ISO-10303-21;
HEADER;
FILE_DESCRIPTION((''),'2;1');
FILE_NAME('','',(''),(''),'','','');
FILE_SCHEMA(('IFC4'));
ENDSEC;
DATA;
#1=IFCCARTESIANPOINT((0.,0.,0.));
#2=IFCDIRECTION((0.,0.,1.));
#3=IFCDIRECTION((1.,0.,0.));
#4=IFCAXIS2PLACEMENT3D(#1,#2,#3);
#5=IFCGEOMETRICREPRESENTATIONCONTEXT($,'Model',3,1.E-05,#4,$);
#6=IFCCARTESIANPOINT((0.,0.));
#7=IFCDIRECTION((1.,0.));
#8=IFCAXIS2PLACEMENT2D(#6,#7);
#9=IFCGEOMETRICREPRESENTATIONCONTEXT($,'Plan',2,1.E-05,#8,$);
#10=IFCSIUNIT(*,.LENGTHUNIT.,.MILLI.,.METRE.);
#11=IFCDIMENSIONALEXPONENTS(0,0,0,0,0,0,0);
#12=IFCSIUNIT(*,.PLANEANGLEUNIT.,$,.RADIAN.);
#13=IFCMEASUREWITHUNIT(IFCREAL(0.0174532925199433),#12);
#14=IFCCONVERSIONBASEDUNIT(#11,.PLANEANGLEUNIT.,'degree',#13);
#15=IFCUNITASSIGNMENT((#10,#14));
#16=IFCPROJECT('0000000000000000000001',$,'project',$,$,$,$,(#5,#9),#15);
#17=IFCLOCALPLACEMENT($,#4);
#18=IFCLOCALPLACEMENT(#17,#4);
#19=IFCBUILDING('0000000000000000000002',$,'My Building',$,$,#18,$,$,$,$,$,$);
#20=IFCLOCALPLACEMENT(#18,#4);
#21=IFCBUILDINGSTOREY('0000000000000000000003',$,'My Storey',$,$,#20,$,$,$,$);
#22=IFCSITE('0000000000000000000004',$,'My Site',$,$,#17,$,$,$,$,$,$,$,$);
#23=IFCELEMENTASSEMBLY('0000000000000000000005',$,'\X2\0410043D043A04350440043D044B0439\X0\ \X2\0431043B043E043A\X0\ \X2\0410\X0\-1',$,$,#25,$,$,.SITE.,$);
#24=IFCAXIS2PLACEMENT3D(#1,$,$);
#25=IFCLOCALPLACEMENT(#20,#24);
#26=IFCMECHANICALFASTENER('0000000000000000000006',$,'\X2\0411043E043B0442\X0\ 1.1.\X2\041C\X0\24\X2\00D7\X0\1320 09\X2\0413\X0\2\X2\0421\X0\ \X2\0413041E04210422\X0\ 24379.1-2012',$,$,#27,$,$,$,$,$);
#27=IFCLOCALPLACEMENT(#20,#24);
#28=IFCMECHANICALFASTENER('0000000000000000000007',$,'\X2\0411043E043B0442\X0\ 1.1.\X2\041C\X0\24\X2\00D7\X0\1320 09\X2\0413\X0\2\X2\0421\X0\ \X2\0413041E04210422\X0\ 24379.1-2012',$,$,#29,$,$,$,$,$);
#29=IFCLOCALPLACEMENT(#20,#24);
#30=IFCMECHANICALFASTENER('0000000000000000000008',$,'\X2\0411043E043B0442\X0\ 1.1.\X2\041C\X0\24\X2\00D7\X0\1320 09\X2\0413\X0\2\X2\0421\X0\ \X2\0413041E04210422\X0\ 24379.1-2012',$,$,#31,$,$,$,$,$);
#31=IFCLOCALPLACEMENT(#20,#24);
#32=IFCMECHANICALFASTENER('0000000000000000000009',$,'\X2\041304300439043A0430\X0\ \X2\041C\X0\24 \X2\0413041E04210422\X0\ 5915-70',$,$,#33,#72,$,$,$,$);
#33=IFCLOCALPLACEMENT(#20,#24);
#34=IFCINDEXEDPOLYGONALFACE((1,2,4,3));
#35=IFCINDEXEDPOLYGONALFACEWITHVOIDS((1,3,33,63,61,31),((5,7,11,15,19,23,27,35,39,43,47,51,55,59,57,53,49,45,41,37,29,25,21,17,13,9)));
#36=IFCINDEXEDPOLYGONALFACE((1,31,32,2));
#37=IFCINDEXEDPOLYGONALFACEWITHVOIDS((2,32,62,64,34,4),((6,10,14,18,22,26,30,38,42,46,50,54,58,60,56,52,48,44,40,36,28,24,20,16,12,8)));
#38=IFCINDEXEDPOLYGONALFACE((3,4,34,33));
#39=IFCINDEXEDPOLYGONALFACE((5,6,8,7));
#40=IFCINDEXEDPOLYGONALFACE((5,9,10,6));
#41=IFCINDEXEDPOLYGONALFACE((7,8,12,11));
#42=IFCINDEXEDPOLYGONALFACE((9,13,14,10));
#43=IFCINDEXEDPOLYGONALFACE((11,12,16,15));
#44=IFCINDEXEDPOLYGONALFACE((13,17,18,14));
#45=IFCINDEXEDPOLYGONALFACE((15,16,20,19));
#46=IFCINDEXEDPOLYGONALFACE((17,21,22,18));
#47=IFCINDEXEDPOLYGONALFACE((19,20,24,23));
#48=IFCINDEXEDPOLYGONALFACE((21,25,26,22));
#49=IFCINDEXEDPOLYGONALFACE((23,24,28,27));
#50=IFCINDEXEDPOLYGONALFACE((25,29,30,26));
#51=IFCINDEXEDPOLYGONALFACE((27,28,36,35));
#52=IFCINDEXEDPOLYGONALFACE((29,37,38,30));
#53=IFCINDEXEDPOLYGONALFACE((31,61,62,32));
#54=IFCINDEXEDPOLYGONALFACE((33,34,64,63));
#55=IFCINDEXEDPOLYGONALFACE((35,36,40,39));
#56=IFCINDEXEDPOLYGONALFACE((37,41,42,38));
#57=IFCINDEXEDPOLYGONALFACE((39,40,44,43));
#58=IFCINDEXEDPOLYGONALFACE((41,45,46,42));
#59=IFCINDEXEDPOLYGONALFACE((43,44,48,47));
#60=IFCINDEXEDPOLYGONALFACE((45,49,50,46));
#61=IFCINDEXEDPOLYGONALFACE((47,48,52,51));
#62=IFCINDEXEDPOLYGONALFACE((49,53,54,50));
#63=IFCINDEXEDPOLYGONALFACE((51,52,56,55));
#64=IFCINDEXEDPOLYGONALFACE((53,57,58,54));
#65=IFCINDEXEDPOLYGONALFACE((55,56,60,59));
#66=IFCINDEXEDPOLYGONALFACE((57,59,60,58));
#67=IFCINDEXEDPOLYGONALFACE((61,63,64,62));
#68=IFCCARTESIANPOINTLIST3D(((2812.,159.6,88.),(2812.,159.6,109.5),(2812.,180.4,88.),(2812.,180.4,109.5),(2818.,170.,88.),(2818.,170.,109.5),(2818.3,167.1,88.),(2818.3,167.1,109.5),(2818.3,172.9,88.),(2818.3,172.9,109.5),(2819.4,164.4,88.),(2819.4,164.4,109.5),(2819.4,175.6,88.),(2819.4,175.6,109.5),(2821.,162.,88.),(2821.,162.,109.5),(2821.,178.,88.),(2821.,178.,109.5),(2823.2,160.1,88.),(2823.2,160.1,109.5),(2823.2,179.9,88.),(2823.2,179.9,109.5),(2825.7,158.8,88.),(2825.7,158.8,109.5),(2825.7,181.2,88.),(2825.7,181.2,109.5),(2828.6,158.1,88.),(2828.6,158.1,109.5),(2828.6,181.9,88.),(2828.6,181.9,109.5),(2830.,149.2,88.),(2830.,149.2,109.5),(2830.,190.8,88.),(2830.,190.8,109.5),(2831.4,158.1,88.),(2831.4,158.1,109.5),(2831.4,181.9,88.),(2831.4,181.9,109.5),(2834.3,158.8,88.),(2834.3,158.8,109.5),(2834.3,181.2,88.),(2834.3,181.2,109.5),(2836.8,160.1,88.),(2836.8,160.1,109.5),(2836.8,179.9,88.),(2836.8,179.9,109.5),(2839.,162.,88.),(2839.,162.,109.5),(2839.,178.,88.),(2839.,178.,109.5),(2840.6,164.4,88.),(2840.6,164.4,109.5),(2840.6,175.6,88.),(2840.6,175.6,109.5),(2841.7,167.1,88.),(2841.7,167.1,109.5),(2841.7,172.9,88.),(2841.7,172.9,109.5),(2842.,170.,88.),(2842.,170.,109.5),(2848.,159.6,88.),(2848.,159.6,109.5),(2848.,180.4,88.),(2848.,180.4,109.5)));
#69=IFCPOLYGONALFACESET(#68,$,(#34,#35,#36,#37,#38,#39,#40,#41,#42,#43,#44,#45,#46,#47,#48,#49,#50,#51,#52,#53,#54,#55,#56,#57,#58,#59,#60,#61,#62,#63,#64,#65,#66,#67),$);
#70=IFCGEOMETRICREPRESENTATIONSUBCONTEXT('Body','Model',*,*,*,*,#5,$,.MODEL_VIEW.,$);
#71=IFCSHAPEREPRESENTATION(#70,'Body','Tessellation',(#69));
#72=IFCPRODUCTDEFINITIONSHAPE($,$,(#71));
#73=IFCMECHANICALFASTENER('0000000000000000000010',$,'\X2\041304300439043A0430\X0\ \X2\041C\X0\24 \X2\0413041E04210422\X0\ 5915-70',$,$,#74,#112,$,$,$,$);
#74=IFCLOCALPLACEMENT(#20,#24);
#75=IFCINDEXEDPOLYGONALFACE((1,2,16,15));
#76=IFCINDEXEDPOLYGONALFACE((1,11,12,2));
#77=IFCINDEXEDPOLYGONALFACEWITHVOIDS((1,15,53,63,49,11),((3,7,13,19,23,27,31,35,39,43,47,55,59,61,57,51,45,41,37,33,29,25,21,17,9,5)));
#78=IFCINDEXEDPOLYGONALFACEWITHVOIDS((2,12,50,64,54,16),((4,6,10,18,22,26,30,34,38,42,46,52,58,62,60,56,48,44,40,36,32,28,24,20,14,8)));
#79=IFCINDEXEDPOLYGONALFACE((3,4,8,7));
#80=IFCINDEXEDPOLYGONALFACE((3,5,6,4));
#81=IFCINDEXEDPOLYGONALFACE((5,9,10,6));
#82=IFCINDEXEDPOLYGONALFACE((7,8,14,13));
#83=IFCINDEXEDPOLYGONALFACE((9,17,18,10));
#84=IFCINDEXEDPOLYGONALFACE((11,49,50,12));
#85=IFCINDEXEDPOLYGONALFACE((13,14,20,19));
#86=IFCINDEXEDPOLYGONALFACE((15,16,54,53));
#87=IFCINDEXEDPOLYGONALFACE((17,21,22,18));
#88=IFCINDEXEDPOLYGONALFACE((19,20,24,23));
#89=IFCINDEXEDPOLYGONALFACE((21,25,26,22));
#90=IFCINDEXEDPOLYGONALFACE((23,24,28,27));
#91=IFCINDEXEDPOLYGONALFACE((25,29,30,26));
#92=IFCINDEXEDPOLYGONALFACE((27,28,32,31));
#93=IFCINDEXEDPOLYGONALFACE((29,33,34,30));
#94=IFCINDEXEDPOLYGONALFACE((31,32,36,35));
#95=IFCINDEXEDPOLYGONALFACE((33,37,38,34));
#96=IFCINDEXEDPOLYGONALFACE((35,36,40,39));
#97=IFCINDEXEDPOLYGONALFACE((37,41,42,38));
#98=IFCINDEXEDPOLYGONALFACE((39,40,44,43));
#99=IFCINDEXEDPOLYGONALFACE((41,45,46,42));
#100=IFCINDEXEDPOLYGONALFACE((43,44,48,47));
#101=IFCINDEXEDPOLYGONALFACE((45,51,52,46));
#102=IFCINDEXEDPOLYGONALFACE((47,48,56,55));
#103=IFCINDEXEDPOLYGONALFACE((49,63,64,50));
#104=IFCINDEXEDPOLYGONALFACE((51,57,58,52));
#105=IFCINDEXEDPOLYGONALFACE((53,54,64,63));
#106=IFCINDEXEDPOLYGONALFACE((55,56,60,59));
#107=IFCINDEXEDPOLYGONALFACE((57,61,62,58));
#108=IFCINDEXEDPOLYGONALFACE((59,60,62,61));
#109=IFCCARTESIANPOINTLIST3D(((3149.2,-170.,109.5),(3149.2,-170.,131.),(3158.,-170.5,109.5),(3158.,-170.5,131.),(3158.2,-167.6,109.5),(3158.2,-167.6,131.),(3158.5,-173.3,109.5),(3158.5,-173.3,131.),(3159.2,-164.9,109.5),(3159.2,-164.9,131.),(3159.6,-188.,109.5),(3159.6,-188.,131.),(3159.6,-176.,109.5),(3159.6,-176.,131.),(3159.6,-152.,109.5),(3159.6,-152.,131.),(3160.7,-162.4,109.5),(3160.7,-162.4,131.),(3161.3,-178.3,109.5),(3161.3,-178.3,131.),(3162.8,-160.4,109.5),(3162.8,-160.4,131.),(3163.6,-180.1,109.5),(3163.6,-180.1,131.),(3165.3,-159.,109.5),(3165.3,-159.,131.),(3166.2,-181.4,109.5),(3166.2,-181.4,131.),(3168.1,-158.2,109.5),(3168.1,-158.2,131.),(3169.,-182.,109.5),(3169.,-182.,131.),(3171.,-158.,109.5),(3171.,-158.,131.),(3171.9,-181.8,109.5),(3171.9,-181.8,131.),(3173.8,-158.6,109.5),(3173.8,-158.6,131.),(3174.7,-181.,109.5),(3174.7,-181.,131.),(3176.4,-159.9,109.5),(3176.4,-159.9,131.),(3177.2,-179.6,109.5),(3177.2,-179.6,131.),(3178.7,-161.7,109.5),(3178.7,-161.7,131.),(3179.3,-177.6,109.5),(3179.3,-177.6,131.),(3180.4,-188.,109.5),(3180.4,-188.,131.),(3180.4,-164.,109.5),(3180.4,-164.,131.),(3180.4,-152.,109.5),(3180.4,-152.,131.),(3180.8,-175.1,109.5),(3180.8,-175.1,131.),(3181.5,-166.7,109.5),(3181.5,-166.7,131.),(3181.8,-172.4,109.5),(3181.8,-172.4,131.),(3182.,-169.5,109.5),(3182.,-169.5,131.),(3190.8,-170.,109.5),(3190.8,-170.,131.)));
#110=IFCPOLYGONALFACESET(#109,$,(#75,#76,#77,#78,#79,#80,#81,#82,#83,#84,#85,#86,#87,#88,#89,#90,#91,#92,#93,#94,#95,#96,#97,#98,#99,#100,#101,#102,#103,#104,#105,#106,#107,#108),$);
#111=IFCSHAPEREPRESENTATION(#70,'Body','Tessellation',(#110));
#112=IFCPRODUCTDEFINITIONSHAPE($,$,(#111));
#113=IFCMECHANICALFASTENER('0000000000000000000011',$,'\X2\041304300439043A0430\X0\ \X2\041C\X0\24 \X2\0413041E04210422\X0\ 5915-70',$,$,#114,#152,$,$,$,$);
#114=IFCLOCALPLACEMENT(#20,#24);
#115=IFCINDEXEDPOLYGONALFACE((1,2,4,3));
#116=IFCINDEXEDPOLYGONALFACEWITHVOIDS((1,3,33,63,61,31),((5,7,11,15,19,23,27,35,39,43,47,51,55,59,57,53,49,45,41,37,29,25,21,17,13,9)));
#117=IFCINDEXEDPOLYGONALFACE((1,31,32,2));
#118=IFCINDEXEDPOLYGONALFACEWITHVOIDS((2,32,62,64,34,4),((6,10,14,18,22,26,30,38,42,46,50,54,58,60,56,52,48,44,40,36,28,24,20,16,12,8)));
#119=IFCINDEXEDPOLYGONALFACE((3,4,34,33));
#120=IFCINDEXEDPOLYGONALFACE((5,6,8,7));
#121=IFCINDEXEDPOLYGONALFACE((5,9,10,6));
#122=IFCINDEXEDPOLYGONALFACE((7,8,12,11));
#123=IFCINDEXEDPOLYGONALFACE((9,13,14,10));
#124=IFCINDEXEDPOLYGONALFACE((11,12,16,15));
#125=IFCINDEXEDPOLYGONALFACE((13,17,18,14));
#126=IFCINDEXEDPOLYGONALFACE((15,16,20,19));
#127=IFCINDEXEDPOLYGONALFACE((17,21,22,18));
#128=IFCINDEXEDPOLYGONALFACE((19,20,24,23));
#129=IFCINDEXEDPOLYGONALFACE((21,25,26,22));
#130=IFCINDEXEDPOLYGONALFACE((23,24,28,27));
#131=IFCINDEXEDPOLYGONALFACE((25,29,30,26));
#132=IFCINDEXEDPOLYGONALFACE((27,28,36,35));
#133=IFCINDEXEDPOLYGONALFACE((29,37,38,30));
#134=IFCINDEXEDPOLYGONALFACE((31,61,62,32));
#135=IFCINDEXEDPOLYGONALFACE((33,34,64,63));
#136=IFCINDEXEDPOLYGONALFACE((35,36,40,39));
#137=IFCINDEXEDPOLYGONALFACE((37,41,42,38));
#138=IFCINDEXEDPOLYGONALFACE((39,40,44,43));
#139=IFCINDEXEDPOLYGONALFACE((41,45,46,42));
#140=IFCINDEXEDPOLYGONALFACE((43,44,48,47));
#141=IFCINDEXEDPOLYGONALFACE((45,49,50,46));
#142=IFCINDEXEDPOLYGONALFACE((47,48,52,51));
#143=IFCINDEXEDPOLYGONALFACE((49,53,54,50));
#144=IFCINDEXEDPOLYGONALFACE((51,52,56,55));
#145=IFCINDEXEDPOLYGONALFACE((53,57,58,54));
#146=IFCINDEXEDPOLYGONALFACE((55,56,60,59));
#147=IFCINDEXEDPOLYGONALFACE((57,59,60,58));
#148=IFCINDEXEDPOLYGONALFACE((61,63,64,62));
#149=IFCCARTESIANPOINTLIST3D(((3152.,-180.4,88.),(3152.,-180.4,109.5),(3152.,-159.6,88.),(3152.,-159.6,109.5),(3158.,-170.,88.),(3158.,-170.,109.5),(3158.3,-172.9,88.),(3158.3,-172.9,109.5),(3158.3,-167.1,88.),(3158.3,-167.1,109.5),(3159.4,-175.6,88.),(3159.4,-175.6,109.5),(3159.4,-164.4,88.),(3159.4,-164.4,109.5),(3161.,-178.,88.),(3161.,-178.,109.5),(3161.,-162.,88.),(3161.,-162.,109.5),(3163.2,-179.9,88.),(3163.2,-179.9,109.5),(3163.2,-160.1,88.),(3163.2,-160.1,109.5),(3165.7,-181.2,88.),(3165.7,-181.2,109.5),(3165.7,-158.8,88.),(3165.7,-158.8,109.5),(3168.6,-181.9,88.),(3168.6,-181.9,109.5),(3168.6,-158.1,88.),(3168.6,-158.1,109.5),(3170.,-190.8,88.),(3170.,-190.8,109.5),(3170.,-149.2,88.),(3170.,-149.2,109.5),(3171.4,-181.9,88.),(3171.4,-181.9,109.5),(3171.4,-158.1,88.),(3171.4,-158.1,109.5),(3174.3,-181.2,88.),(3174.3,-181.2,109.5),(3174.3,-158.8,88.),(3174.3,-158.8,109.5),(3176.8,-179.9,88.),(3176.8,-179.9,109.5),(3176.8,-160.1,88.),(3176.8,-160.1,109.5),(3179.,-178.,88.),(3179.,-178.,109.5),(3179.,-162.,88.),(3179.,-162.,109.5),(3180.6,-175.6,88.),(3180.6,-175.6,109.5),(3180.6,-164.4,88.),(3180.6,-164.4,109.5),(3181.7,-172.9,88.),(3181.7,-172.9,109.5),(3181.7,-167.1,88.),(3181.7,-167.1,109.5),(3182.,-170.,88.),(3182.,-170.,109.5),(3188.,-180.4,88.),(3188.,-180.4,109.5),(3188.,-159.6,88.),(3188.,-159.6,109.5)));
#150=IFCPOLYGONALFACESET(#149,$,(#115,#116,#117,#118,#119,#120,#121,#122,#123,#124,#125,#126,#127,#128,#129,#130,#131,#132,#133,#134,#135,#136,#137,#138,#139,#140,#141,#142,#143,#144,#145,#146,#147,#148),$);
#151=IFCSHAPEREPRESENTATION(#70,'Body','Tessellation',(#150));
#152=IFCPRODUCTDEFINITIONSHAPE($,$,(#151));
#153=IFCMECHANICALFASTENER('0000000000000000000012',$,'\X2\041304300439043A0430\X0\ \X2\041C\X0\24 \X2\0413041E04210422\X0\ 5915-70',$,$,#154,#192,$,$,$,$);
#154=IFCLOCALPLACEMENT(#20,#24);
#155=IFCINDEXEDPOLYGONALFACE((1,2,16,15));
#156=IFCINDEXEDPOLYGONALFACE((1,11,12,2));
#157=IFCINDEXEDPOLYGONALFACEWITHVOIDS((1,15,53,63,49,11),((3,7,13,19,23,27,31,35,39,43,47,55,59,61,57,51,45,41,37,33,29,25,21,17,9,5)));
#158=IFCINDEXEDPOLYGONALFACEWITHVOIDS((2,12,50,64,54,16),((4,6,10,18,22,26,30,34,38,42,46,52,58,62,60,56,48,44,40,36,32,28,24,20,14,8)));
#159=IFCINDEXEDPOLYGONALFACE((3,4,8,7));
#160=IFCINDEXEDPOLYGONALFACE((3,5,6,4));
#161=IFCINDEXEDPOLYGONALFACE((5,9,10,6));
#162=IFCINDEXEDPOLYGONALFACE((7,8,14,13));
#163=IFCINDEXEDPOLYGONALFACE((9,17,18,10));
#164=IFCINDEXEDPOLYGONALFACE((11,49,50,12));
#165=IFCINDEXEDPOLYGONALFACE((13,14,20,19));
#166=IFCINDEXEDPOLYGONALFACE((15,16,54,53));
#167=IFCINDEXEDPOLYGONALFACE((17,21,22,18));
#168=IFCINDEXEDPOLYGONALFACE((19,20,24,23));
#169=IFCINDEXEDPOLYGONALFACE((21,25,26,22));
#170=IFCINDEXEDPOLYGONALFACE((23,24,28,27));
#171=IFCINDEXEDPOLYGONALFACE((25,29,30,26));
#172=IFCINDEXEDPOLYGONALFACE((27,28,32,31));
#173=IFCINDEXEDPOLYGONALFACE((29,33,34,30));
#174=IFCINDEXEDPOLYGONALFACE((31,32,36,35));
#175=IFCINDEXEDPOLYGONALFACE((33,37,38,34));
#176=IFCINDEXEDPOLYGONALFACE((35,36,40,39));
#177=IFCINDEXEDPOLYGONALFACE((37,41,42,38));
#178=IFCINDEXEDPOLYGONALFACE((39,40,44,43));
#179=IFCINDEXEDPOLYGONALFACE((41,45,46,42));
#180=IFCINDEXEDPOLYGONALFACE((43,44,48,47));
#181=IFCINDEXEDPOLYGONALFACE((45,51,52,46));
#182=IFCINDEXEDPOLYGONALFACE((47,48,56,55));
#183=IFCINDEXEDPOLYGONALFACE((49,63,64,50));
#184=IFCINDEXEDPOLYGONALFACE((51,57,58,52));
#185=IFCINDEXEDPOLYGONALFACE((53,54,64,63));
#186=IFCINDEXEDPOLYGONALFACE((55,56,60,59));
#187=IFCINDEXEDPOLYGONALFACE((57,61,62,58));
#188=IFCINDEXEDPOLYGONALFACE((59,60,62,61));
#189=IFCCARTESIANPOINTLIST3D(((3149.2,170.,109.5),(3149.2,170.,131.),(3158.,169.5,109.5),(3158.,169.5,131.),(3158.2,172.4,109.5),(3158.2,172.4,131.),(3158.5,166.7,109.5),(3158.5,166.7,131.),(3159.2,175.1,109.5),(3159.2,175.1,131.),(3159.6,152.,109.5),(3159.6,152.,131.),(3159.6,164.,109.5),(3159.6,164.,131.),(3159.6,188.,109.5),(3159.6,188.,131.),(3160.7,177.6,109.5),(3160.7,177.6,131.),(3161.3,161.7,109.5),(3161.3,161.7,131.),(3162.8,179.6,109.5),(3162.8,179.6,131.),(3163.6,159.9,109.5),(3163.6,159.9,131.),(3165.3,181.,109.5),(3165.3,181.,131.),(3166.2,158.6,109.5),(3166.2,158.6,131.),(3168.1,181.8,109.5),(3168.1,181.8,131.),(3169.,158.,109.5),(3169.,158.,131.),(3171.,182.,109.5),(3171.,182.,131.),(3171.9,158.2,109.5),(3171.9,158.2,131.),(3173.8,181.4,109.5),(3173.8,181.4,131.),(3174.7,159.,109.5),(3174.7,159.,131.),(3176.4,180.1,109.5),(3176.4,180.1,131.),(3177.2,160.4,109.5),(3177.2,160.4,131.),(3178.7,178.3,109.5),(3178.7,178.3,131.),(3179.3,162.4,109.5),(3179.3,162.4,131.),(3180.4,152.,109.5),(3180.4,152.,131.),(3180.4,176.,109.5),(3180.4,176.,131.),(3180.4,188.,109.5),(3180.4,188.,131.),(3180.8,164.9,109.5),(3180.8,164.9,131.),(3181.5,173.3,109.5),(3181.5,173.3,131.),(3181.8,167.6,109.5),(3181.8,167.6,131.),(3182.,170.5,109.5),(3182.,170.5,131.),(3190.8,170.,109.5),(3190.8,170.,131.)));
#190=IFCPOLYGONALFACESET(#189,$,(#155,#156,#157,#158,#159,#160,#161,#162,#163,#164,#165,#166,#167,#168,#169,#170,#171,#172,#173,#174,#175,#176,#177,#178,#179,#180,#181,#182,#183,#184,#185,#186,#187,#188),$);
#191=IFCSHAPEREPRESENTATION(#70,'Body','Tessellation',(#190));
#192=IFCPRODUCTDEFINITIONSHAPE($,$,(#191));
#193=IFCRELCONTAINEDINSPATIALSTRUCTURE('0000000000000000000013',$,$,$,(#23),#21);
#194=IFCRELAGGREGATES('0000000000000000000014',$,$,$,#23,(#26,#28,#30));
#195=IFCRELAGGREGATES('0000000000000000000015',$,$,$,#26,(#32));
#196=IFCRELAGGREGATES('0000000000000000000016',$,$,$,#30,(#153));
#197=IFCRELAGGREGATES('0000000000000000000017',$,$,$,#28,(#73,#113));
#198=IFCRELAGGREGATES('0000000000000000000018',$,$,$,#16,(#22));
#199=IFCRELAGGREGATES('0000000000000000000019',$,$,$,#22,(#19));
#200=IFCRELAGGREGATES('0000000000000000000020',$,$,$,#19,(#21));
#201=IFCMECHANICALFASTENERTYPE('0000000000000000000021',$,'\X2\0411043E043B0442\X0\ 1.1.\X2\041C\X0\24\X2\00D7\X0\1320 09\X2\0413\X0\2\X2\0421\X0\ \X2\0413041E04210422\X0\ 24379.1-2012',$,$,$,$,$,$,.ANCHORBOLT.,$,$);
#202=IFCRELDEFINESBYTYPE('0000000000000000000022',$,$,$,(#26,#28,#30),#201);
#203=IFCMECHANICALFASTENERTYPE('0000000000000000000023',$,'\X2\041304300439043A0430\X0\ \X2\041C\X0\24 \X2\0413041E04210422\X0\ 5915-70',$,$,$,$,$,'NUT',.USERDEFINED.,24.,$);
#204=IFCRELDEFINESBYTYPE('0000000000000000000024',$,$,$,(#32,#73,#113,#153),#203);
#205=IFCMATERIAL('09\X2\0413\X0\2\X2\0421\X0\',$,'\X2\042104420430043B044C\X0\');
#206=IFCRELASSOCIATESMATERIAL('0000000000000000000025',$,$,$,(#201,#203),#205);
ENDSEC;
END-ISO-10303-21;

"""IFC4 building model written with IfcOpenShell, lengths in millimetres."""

from ifc_helpers import new_model, entity, si_unit, converted_unit, frame, origin_with_axes, origin_2d_with_axis, place, context, subcontext, project, spatial, polyline, outline, extrude, source, transform, mapped, material, type_object, type_shapes, element, aggregate, save


model = new_model("IFC4")

# Units and contexts
model_context = context("Model", 3, precision=1e-05, world=origin_with_axes())
plan_context = context("Plan", 2, precision=1e-05, world=origin_2d_with_axis())
body_context = subcontext(model_context, "Body", "Model", "MODEL_VIEW")
ifc_project = project(units=[si_unit("LENGTHUNIT", "METRE", prefix="MILLI"), converted_unit("PLANEANGLEUNIT", "degree", entity("IfcReal", 0.0174532925199433), si_unit("PLANEANGLEUNIT", "RADIAN"), dimensions=[0, 0, 0, 0, 0, 0, 0])], contexts=[model_context, plan_context])

# Site, building, storey
site_placement = place(None, origin_with_axes())
site = spatial("IfcSite", under=ifc_project, at=site_placement, Name="My Site")
building_placement = place(site_placement, origin_with_axes())
building = spatial("IfcBuilding", under=site, at=building_placement, Name="My Building")
storey_placement = place(building_placement, origin_with_axes())
storey = spatial("IfcBuildingStorey", under=building, at=storey_placement, Name="My Storey")

# Element assembly
placement_1 = place(storey_placement, frame((3000.0, 0.0, 0.0), z_axis=(0.0, 0.0, 1.0), x_axis=(1.0, 0.0, 0.0)))
assembly_1 = element("IfcElementAssembly", 1, at=placement_1, inside=storey, Name="Анкерный блок А-1", AssemblyPlace="SITE")

# Shared definitions
ifc_material_1 = material(Name="09Г2С", Category="Сталь")
mechanical_fastener_type_1 = type_object("IfcMechanicalFastenerType", Name="Болт 1.1.М24×1320 09Г2С ГОСТ 24379.1-2012", PredefinedType="ANCHORBOLT", material=ifc_material_1)

# Mechanical fasteners
mechanical_fastener_1_placement = place(placement_1, frame((-170.0, 170.0, 0.0), z_axis=(0.0, 0.0, 1.0), x_axis=(-1.0, 0.0, 0.0)))
mechanical_fastener_1 = element("IfcMechanicalFastener", 2, at=mechanical_fastener_1_placement, type_object=mechanical_fastener_type_1, Name="Болт 1.1.М24×1320 09Г2С ГОСТ 24379.1-2012")
mechanical_fastener_2_placement = place(placement_1, frame((170.0, -170.0, 0.0), z_axis=(0.0, 0.0, 1.0), x_axis=(1.0, 0.0, 0.0)))
mechanical_fastener_2 = element("IfcMechanicalFastener", 3, at=mechanical_fastener_2_placement, type_object=mechanical_fastener_type_1, Name="Болт 1.1.М24×1320 09Г2С ГОСТ 24379.1-2012")

# Mechanical fasteners
mechanical_fastener_3_placement = place(placement_1, frame((170.0, 170.0, 0.0), z_axis=(0.0, 0.0, 1.0), x_axis=(-1.0, 0.0, 0.0)))
mechanical_fastener_3 = element("IfcMechanicalFastener", 4, at=mechanical_fastener_3_placement, type_object=mechanical_fastener_type_1, Name="Болт 1.1.М24×1320 09Г2С ГОСТ 24379.1-2012")
aggregate(assembly_1, [mechanical_fastener_1, mechanical_fastener_2, mechanical_fastener_3])
mechanical_fastener_type_2 = type_object("IfcMechanicalFastenerType", Name="Гайка М24 ГОСТ 5915-70", ElementType="NUT", NominalDiameter=24.0, PredefinedType="USERDEFINED", material=ifc_material_1)
shared_shape_1 = source(origin_with_axes(), body_context, "Body", "SweptSolid", [
    extrude(outline(polyline([(-10.4, -18.0), (10.4, -18.0), (20.8, 0.0), (10.4, 18.0), (-10.4, 18.0), (-20.8, 0.0), (-10.4, -18.0)]), holes=[polyline([(-8.0, 9.0), (-5.6, 10.6), (-2.9, 11.7), (0.0, 12.0), (2.9, 11.7), (5.6, 10.6), (8.0, 9.0), (9.9, 6.8), (11.2, 4.3), (11.9, 1.4), (11.9, -1.4), (11.2, -4.3), (9.9, -6.8), (8.0, -9.0), (5.6, -10.6), (2.9, -11.7), (0.0, -12.0), (-2.9, -11.7), (-5.6, -10.6), (-8.0, -9.0), (-9.9, -6.8), (-11.2, -4.3), (-11.9, -1.4), (-11.9, 1.4), (-11.2, 4.3), (-9.9, 6.8), (-8.0, 9.0)])]), frame((0.0, 0.0, 0.0), z_axis=(0.0, 0.0, 1.0), x_axis=(0.0, 1.0, 0.0)), (0.0, 0.0, 1.0), 21.5),
])
type_shapes(mechanical_fastener_type_2, [shared_shape_1])
mechanical_fastener_4_placement = place(mechanical_fastener_1_placement, frame((0.0, 0.0, 88.0), z_axis=(0.0, 0.0, 1.0), x_axis=(1.0, 0.0, 0.0)))
mechanical_fastener_4 = element("IfcMechanicalFastener", 5, at=mechanical_fastener_4_placement, type_object=mechanical_fastener_type_2, Name="Гайка М24 ГОСТ 5915-70", context=body_context, shape_type="MappedRepresentation", body=[
    mapped(shared_shape_1, transform((0.0, 0.0, 0.0), x_axis=(1.0, 0.0, 0.0), y_axis=(0.0, 1.0, 0.0), z_axis=(0.0, 0.0, 1.0), scale=1.0)),
])
aggregate(mechanical_fastener_1, [mechanical_fastener_4])
mechanical_fastener_5_placement = place(mechanical_fastener_2_placement, frame((0.0, 0.0, 109.5), z_axis=(0.0, 0.0, 1.0), x_axis=(0.866025, 0.5, 0.0)))
mechanical_fastener_5 = element("IfcMechanicalFastener", 6, at=mechanical_fastener_5_placement, type_object=mechanical_fastener_type_2, Name="Гайка М24 ГОСТ 5915-70", context=body_context, shape_type="MappedRepresentation", body=[
    mapped(shared_shape_1, transform((0.0, 0.0, 0.0), x_axis=(1.0, 0.0, 0.0), y_axis=(0.0, 1.0, 0.0), z_axis=(0.0, 0.0, 1.0), scale=1.0)),
])
mechanical_fastener_6_placement = place(mechanical_fastener_2_placement, frame((0.0, 0.0, 88.0), z_axis=(0.0, 0.0, 1.0), x_axis=(1.0, 0.0, 0.0)))
mechanical_fastener_6 = element("IfcMechanicalFastener", 7, at=mechanical_fastener_6_placement, type_object=mechanical_fastener_type_2, Name="Гайка М24 ГОСТ 5915-70", context=body_context, shape_type="MappedRepresentation", body=[
    mapped(shared_shape_1, transform((0.0, 0.0, 0.0), x_axis=(1.0, 0.0, 0.0), y_axis=(0.0, 1.0, 0.0), z_axis=(0.0, 0.0, 1.0), scale=1.0)),
])
mechanical_fastener_7_placement = place(mechanical_fastener_3_placement, frame((0.0, 0.0, 109.5), z_axis=(0.0, 0.0, 1.0), x_axis=(0.866025, 0.5, 0.0)))
mechanical_fastener_7 = element("IfcMechanicalFastener", 8, at=mechanical_fastener_7_placement, type_object=mechanical_fastener_type_2, Name="Гайка М24 ГОСТ 5915-70", context=body_context, shape_type="MappedRepresentation", body=[
    mapped(shared_shape_1, transform((0.0, 0.0, 0.0), x_axis=(1.0, 0.0, 0.0), y_axis=(0.0, 1.0, 0.0), z_axis=(0.0, 0.0, 1.0), scale=1.0)),
])
aggregate(mechanical_fastener_3, [mechanical_fastener_7])
aggregate(mechanical_fastener_2, [mechanical_fastener_5, mechanical_fastener_6])

save(model, "model.ifc")
